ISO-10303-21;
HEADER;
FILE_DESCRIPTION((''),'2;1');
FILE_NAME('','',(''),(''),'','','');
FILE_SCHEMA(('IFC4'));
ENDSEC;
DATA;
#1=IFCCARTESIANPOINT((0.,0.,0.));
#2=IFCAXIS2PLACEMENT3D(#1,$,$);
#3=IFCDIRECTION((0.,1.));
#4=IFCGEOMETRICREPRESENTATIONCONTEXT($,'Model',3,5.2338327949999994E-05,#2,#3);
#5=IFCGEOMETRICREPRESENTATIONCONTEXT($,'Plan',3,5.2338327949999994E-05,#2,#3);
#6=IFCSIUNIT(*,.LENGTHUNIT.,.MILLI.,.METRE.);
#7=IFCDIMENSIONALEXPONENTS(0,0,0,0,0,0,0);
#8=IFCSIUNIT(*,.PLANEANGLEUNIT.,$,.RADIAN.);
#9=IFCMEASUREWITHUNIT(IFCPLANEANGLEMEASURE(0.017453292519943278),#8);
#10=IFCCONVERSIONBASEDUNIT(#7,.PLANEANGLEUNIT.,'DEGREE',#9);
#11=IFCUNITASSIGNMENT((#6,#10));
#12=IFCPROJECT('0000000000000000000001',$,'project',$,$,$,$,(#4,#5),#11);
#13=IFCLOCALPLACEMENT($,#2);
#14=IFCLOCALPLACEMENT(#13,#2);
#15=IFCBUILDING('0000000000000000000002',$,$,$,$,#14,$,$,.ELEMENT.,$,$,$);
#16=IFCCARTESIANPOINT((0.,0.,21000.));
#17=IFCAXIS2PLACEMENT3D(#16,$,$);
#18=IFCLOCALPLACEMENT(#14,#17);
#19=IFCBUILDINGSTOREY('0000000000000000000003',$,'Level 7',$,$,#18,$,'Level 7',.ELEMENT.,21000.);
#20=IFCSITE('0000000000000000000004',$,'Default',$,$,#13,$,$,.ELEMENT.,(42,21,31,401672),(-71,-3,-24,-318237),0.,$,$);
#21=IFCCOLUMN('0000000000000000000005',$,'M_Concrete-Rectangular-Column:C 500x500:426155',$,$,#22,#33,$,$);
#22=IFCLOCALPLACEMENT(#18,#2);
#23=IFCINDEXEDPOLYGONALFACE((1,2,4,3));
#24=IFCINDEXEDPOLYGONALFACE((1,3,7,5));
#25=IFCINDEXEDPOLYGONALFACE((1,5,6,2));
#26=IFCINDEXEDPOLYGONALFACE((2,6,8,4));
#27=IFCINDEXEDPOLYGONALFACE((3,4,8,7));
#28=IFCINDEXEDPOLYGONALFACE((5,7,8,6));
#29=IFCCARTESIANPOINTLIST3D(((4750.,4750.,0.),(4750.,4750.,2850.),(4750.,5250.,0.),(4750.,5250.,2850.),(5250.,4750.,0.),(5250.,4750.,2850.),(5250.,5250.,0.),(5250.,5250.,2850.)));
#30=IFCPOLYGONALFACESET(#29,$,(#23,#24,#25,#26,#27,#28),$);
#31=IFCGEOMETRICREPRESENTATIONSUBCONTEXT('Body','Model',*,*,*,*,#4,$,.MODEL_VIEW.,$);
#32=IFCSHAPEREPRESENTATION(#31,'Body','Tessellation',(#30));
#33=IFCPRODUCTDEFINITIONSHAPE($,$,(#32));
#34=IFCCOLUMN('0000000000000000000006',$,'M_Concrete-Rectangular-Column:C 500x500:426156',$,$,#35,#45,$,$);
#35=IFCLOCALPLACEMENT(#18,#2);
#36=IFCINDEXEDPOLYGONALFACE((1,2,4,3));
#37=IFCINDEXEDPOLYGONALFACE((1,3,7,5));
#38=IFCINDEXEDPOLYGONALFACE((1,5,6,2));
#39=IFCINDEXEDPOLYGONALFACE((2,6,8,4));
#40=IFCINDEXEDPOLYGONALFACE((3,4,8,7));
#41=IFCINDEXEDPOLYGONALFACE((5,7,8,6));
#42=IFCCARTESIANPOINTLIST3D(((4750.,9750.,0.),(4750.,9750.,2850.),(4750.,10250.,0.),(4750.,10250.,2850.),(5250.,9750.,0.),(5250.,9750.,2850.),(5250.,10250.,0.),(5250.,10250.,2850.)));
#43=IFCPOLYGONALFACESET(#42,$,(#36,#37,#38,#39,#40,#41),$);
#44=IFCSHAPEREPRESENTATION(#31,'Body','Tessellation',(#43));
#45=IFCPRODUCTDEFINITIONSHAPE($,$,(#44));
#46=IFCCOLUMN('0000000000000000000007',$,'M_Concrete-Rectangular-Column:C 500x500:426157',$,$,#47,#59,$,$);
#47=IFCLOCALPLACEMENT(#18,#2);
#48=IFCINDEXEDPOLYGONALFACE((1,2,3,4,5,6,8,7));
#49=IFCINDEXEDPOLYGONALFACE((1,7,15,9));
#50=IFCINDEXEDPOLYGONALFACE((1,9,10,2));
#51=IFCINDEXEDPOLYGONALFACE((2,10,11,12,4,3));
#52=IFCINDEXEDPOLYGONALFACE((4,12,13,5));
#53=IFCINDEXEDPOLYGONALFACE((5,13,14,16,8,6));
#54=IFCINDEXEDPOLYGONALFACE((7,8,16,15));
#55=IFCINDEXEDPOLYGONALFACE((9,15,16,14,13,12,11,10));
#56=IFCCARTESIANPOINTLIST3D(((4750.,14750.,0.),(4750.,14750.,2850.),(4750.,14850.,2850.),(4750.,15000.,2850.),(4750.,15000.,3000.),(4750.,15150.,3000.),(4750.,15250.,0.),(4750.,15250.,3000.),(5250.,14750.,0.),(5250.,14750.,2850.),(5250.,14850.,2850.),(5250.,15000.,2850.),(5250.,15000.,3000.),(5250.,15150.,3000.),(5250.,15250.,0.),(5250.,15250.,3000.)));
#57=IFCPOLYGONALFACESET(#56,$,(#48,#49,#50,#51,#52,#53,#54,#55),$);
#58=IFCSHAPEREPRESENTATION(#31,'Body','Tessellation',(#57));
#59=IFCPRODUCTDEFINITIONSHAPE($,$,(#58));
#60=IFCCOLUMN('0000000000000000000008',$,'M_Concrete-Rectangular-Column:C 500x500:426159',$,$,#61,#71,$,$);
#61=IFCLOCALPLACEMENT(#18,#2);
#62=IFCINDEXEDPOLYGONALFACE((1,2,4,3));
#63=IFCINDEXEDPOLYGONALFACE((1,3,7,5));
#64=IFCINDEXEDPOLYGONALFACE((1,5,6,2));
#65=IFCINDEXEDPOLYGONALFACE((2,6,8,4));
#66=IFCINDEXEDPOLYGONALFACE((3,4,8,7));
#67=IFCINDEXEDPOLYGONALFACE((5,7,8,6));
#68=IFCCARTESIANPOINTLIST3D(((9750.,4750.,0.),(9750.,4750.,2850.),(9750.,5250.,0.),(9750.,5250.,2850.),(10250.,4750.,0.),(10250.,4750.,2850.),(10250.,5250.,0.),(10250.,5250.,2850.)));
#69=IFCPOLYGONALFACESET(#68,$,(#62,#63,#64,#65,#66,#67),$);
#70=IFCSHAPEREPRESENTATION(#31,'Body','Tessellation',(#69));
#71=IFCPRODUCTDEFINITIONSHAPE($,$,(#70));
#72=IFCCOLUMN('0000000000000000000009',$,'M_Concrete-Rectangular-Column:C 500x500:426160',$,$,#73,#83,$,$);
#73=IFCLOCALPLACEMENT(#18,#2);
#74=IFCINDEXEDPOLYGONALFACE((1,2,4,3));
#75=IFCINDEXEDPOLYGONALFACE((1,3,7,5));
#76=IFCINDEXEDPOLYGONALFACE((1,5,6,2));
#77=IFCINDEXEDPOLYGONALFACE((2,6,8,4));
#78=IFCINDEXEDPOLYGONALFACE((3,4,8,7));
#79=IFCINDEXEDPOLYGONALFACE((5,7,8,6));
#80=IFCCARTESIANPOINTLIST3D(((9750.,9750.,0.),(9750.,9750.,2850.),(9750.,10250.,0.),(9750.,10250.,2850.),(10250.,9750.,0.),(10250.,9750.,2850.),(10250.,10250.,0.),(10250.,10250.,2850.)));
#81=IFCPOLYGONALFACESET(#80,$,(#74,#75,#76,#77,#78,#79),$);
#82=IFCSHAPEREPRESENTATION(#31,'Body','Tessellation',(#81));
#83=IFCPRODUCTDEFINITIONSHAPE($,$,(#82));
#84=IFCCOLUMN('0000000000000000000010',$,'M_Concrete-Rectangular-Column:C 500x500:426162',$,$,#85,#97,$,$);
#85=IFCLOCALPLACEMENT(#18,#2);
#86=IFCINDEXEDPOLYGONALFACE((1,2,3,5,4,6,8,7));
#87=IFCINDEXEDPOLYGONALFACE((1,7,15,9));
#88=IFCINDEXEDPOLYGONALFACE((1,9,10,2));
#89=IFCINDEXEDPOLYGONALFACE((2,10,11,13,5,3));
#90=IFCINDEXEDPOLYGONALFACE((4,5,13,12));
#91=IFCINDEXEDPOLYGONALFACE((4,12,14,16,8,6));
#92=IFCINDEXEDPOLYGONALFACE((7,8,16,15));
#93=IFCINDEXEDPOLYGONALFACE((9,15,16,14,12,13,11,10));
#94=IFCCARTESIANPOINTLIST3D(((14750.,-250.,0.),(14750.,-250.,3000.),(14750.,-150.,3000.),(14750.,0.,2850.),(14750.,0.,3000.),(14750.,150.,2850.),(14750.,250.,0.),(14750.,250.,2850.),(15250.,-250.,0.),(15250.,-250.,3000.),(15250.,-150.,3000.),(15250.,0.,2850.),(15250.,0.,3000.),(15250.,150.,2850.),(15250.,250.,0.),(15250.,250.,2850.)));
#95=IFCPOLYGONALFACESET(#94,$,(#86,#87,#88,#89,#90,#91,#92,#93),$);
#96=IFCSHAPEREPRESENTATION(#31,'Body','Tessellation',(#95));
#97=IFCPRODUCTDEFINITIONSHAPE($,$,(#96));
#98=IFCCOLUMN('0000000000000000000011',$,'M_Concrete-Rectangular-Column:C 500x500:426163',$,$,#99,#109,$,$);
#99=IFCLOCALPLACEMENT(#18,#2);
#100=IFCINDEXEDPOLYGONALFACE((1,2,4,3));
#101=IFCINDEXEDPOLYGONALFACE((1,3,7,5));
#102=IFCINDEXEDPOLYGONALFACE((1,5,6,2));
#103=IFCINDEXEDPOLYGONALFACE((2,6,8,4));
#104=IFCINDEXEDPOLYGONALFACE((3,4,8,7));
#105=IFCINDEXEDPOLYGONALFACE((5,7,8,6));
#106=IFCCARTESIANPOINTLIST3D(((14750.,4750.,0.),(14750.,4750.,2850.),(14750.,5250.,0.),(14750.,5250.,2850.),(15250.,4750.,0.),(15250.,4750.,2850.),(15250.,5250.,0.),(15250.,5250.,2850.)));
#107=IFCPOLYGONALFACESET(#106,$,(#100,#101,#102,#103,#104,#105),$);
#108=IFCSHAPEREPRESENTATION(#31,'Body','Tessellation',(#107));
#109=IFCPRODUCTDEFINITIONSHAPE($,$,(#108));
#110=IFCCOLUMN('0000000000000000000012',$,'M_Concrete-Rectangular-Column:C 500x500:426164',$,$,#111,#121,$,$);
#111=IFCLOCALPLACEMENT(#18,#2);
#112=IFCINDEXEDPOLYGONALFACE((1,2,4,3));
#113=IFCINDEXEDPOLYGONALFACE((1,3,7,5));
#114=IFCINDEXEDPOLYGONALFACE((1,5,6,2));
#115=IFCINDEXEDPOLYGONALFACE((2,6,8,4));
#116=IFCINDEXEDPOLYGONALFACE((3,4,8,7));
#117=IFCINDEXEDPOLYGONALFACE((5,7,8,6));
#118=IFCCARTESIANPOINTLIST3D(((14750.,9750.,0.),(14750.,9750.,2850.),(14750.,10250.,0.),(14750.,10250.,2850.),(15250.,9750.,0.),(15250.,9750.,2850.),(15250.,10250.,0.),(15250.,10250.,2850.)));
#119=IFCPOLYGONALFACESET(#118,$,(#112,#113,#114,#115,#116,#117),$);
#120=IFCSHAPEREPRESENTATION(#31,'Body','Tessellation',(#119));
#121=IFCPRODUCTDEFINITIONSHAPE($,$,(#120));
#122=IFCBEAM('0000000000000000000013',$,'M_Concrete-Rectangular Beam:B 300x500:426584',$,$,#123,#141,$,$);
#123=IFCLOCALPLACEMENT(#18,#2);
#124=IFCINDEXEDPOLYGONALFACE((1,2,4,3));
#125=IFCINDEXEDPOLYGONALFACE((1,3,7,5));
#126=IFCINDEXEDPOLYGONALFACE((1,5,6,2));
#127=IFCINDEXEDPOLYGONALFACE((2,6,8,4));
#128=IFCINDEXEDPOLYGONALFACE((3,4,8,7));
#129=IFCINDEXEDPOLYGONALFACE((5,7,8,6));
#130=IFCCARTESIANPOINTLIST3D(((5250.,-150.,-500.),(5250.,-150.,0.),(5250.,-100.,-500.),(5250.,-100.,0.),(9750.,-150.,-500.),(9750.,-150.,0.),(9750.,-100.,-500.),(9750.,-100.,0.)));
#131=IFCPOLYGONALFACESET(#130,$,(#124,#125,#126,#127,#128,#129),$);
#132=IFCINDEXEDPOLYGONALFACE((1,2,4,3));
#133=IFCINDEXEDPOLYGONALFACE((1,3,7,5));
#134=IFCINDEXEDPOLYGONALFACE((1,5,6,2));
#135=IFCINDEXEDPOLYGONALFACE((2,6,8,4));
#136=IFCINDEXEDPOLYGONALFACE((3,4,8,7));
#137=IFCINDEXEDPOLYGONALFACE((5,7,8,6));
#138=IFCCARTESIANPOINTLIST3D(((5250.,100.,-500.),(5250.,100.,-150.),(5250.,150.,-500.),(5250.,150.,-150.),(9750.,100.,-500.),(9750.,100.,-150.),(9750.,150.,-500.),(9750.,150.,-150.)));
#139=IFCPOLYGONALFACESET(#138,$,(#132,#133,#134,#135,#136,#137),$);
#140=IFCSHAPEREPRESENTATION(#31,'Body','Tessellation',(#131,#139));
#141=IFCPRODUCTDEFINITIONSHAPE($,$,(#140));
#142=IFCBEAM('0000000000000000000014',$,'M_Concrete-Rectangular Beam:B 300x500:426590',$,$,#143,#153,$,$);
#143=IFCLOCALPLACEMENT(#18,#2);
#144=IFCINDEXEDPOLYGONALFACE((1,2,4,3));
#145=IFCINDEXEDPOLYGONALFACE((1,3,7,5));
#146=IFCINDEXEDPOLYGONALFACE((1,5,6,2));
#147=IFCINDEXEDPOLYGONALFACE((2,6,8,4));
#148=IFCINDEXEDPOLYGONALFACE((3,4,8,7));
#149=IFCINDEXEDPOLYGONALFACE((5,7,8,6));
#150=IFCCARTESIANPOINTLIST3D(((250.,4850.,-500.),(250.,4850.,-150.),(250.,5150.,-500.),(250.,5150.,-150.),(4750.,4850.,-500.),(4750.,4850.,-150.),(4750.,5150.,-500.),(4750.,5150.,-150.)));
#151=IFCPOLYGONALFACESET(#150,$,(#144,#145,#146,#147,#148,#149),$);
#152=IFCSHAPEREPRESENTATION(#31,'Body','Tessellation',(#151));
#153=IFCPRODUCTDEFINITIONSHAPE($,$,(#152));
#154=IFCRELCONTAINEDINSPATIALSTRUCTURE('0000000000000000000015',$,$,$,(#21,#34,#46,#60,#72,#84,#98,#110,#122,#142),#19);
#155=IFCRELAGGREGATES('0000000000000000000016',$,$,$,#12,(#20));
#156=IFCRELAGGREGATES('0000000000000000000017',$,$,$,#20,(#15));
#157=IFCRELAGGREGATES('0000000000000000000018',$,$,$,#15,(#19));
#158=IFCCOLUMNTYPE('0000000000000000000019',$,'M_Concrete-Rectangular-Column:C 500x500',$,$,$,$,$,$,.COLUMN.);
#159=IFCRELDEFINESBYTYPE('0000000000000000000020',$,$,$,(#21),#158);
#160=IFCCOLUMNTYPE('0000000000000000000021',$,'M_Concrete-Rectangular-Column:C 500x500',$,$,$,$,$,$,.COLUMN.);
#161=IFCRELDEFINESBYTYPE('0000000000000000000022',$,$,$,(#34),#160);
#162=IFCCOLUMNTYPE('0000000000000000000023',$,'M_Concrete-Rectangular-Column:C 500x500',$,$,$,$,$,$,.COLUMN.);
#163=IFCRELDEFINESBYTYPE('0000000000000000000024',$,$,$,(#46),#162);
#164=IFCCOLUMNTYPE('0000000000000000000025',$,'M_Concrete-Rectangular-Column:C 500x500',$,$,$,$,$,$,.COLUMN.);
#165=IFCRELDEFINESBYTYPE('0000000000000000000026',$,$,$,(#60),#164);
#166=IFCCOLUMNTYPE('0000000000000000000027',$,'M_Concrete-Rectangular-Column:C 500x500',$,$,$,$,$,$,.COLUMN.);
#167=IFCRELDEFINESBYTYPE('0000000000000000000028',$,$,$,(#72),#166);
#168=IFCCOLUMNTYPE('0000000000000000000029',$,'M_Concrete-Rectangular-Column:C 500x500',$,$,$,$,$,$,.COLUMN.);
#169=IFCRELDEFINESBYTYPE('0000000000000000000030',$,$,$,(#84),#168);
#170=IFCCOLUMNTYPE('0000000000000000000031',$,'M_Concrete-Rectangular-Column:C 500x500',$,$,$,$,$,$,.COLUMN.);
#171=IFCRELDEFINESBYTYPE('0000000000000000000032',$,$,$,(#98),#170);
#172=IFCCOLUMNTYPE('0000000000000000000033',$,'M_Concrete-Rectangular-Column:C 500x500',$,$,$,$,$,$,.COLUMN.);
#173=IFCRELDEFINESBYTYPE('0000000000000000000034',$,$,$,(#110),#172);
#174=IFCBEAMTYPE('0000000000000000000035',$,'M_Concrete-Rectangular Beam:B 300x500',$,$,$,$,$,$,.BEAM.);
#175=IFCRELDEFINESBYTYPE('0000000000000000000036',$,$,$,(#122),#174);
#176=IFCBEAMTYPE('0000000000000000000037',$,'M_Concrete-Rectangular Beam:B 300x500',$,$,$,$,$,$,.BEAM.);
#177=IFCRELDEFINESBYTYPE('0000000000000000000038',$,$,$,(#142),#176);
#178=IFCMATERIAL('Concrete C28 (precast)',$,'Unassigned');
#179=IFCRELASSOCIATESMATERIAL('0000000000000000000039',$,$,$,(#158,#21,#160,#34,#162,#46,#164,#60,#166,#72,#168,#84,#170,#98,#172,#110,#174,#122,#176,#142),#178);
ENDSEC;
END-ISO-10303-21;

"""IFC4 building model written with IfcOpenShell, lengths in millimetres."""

from ifc_helpers import new_model, entity, si_unit, converted_unit, direction, frame, origin, place, context, subcontext, project, spatial, indexed_curve, outline, extrude, source, transform, mapped, material, type_object, type_shapes, element, save


model = new_model("IFC4")

# Units and contexts
model_context = context("Model", 3, precision=5.2338327949999994e-05, world=origin(), true_north=direction((0.0, 1.0)))
plan_context = context("Plan", 3, precision=5.2338327949999994e-05, world=origin(), true_north=direction((0.0, 1.0)))
body_context = subcontext(model_context, "Body", "Model", "MODEL_VIEW")
ifc_project = project(units=[si_unit("LENGTHUNIT", "METRE", prefix="MILLI"), converted_unit("PLANEANGLEUNIT", "DEGREE", entity("IfcPlaneAngleMeasure", 0.017453292519943278), si_unit("PLANEANGLEUNIT", "RADIAN"), dimensions=[0, 0, 0, 0, 0, 0, 0])], contexts=[model_context, plan_context])

# Site, building, storey
site_placement = place(None, origin())
site = spatial("IfcSite", under=ifc_project, at=site_placement, Name="Default", CompositionType="ELEMENT", RefLatitude=(42, 21, 31, 401672), RefLongitude=(-71, -3, -24, -318237), RefElevation=0.0)
building_placement = place(site_placement, origin())
building = spatial("IfcBuilding", under=site, at=building_placement, CompositionType="ELEMENT")
storey_placement = place(building_placement, frame((0.0, 0.0, 21000.0)))
storey = spatial("IfcBuildingStorey", under=building, at=storey_placement, Name="Level 7", LongName="Level 7", CompositionType="ELEMENT", Elevation=21000.0)

# Columns
ifc_material = material(Name="Concrete C28 (precast)", Category="Unassigned")
column_type_1 = type_object("IfcColumnType", Name="M_Concrete-Rectangular-Column:C 500x500", PredefinedType="COLUMN", material=ifc_material)
shared_shape_1 = source(origin(), body_context, "Body", "SweptSolid", [
    extrude(outline(indexed_curve([(-250.0, -250.0), (250.0, -250.0), (250.0, 250.0), (-250.0, 250.0), (-250.0, -250.0)], self_intersect=False)), frame((5000.0, 5000.0, 21000.0), z_axis=(0.0, 0.0, 1.0), x_axis=(-1.0, 0.0, 0.0)), (0.0, 0.0, 1.0), 2850.0),
])
type_shapes(column_type_1, [shared_shape_1])
column_1_placement = place(storey_placement, frame((0.0, 0.0, -21000.0)))
element("IfcColumn", 1, at=column_1_placement, inside=storey, type_object=column_type_1, material=ifc_material, Name="M_Concrete-Rectangular-Column:C 500x500:426155", context=body_context, shape_type="MappedRepresentation", body=[
    mapped(shared_shape_1, transform((0.0, 0.0, 0.0), scale=1.0)),
])
column_type_2 = type_object("IfcColumnType", Name="M_Concrete-Rectangular-Column:C 500x500", PredefinedType="COLUMN", material=ifc_material)
shared_shape_2 = source(origin(), body_context, "Body", "SweptSolid", [
    extrude(outline(indexed_curve([(-250.0, -250.0), (250.0, -250.0), (250.0, 250.0), (-250.0, 250.0), (-250.0, -250.0)], self_intersect=False)), frame((5000.0, 10000.0, 21000.0), z_axis=(0.0, 0.0, 1.0), x_axis=(-1.0, 0.0, 0.0)), (0.0, 0.0, 1.0), 2850.0),
])
type_shapes(column_type_2, [shared_shape_2])
column_2_placement = place(storey_placement, frame((0.0, 0.0, -21000.0)))
element("IfcColumn", 2, at=column_2_placement, inside=storey, type_object=column_type_2, material=ifc_material, Name="M_Concrete-Rectangular-Column:C 500x500:426156", context=body_context, shape_type="MappedRepresentation", body=[
    mapped(shared_shape_2, transform((0.0, 0.0, 0.0), scale=1.0)),
])
column_type_3 = type_object("IfcColumnType", Name="M_Concrete-Rectangular-Column:C 500x500", PredefinedType="COLUMN", material=ifc_material)
shared_shape_3 = source(origin(), body_context, "Body", "SweptSolid", [
    extrude(outline(indexed_curve([(-2193.7, -250.0), (806.2, -250.0), (806.2, -150.0), (806.2, 0.0), (656.2, 0.0), (656.2, 150.0), (656.2, 250.0), (-2193.7, 250.0), (-2193.7, -250.0)], self_intersect=False)), frame((4750.0, 15000.0, 23193.8), z_axis=(1.0, 0.0, 0.0), x_axis=(0.0, 0.0, 1.0)), (0.0, 0.0, 1.0), 500.0),
])
type_shapes(column_type_3, [shared_shape_3])
column_3_placement = place(storey_placement, frame((0.0, 0.0, -21000.0)))
element("IfcColumn", 3, at=column_3_placement, inside=storey, type_object=column_type_3, material=ifc_material, Name="M_Concrete-Rectangular-Column:C 500x500:426157", context=body_context, shape_type="MappedRepresentation", body=[
    mapped(shared_shape_3, transform((0.0, 0.0, 0.0), scale=1.0)),
])
column_type_4 = type_object("IfcColumnType", Name="M_Concrete-Rectangular-Column:C 500x500", PredefinedType="COLUMN", material=ifc_material)
shared_shape_4 = source(origin(), body_context, "Body", "SweptSolid", [
    extrude(outline(indexed_curve([(-250.0, -250.0), (250.0, -250.0), (250.0, 250.0), (-250.0, 250.0), (-250.0, -250.0)], self_intersect=False)), frame((10000.0, 5000.0, 21000.0), z_axis=(0.0, 0.0, 1.0), x_axis=(-1.0, 0.0, 0.0)), (0.0, 0.0, 1.0), 2850.0),
])
type_shapes(column_type_4, [shared_shape_4])
column_4_placement = place(storey_placement, frame((0.0, 0.0, -21000.0)))
element("IfcColumn", 4, at=column_4_placement, inside=storey, type_object=column_type_4, material=ifc_material, Name="M_Concrete-Rectangular-Column:C 500x500:426159", context=body_context, shape_type="MappedRepresentation", body=[
    mapped(shared_shape_4, transform((0.0, 0.0, 0.0), scale=1.0)),
])
column_type_5 = type_object("IfcColumnType", Name="M_Concrete-Rectangular-Column:C 500x500", PredefinedType="COLUMN", material=ifc_material)
shared_shape_5 = source(origin(), body_context, "Body", "SweptSolid", [
    extrude(outline(indexed_curve([(-250.0, -250.0), (250.0, -250.0), (250.0, 250.0), (-250.0, 250.0), (-250.0, -250.0)], self_intersect=False)), frame((10000.0, 10000.0, 21000.0), z_axis=(0.0, 0.0, 1.0), x_axis=(-1.0, 0.0, 0.0)), (0.0, 0.0, 1.0), 2850.0),
])
type_shapes(column_type_5, [shared_shape_5])
column_5_placement = place(storey_placement, frame((0.0, 0.0, -21000.0)))
element("IfcColumn", 5, at=column_5_placement, inside=storey, type_object=column_type_5, material=ifc_material, Name="M_Concrete-Rectangular-Column:C 500x500:426160", context=body_context, shape_type="MappedRepresentation", body=[
    mapped(shared_shape_5, transform((0.0, 0.0, 0.0), scale=1.0)),
])
column_type_6 = type_object("IfcColumnType", Name="M_Concrete-Rectangular-Column:C 500x500", PredefinedType="COLUMN", material=ifc_material)
shared_shape_6 = source(origin(), body_context, "Body", "SweptSolid", [
    extrude(outline(indexed_curve([(-2193.7, -250.0), (656.2, -250.0), (656.2, -150.0), (656.2, 0.0), (806.2, 0.0), (806.2, 150.0), (806.2, 250.0), (-2193.7, 250.0), (-2193.7, -250.0)], self_intersect=False)), frame((14750.0, 0.0, 23193.8), z_axis=(1.0, 0.0, 0.0), x_axis=(0.0, 0.0, 1.0)), (0.0, 0.0, 1.0), 500.0),
])
type_shapes(column_type_6, [shared_shape_6])
column_6_placement = place(storey_placement, frame((0.0, 0.0, -21000.0)))
element("IfcColumn", 6, at=column_6_placement, inside=storey, type_object=column_type_6, material=ifc_material, Name="M_Concrete-Rectangular-Column:C 500x500:426162", context=body_context, shape_type="MappedRepresentation", body=[
    mapped(shared_shape_6, transform((0.0, 0.0, 0.0), scale=1.0)),
])
column_type_7 = type_object("IfcColumnType", Name="M_Concrete-Rectangular-Column:C 500x500", PredefinedType="COLUMN", material=ifc_material)
shared_shape_7 = source(origin(), body_context, "Body", "SweptSolid", [
    extrude(outline(indexed_curve([(-250.0, -250.0), (250.0, -250.0), (250.0, 250.0), (-250.0, 250.0), (-250.0, -250.0)], self_intersect=False)), frame((15000.0, 5000.0, 21000.0), z_axis=(0.0, 0.0, 1.0), x_axis=(-1.0, 0.0, 0.0)), (0.0, 0.0, 1.0), 2850.0),
])
type_shapes(column_type_7, [shared_shape_7])
column_7_placement = place(storey_placement, frame((0.0, 0.0, -21000.0)))
element("IfcColumn", 7, at=column_7_placement, inside=storey, type_object=column_type_7, material=ifc_material, Name="M_Concrete-Rectangular-Column:C 500x500:426163", context=body_context, shape_type="MappedRepresentation", body=[
    mapped(shared_shape_7, transform((0.0, 0.0, 0.0), scale=1.0)),
])
column_type_8 = type_object("IfcColumnType", Name="M_Concrete-Rectangular-Column:C 500x500", PredefinedType="COLUMN", material=ifc_material)
shared_shape_8 = source(origin(), body_context, "Body", "SweptSolid", [
    extrude(outline(indexed_curve([(-250.0, -250.0), (250.0, -250.0), (250.0, 250.0), (-250.0, 250.0), (-250.0, -250.0)], self_intersect=False)), frame((15000.0, 10000.0, 21000.0), z_axis=(0.0, 0.0, 1.0), x_axis=(-1.0, 0.0, 0.0)), (0.0, 0.0, 1.0), 2850.0),
])
type_shapes(column_type_8, [shared_shape_8])
column_8_placement = place(storey_placement, frame((0.0, 0.0, -21000.0)))
element("IfcColumn", 8, at=column_8_placement, inside=storey, type_object=column_type_8, material=ifc_material, Name="M_Concrete-Rectangular-Column:C 500x500:426164", context=body_context, shape_type="MappedRepresentation", body=[
    mapped(shared_shape_8, transform((0.0, 0.0, 0.0), scale=1.0)),
])

# Beams
beam_type_1 = type_object("IfcBeamType", Name="M_Concrete-Rectangular Beam:B 300x500", PredefinedType="BEAM", material=ifc_material)
shared_shape_9 = source(origin(), body_context, "Body", "SweptSolid", [
    extrude(outline(indexed_curve([(-250.0, -25.0), (250.0, -25.0), (250.0, 25.0), (-250.0, 25.0), (-250.0, -25.0)], self_intersect=False)), frame((5250.0, -125.0, 20750.0), z_axis=(1.0, 0.0, 0.0), x_axis=(0.0, 0.0, -1.0)), (0.0, 0.0, 1.0), 4500.0),
    extrude(outline(indexed_curve([(-175.0, -25.0), (175.0, -25.0), (175.0, 25.0), (-175.0, 25.0), (-175.0, -25.0)], self_intersect=False)), frame((5250.0, 125.0, 20675.0), z_axis=(1.0, 0.0, 0.0), x_axis=(0.0, 0.0, -1.0)), (0.0, 0.0, 1.0), 4500.0),
])
type_shapes(beam_type_1, [shared_shape_9])
beam_1_placement = place(storey_placement, frame((0.0, 0.0, -21000.0)))
element("IfcBeam", 9, at=beam_1_placement, inside=storey, type_object=beam_type_1, material=ifc_material, Name="M_Concrete-Rectangular Beam:B 300x500:426584", context=body_context, shape_type="MappedRepresentation", body=[
    mapped(shared_shape_9, transform((0.0, 0.0, 0.0), scale=1.0)),
])
beam_type_2 = type_object("IfcBeamType", Name="M_Concrete-Rectangular Beam:B 300x500", PredefinedType="BEAM", material=ifc_material)
shared_shape_10 = source(origin(), body_context, "Body", "SweptSolid", [
    extrude(outline(indexed_curve([(-175.0, -150.0), (175.0, -150.0), (175.0, 150.0), (-175.0, 150.0), (-175.0, -150.0)], self_intersect=False)), frame((250.0, 5000.0, 20675.0), z_axis=(1.0, 0.0, 0.0), x_axis=(0.0, 0.0, -1.0)), (0.0, 0.0, 1.0), 4500.0),
])
type_shapes(beam_type_2, [shared_shape_10])
beam_2_placement = place(storey_placement, frame((0.0, 0.0, -21000.0)))
element("IfcBeam", 10, at=beam_2_placement, inside=storey, type_object=beam_type_2, material=ifc_material, Name="M_Concrete-Rectangular Beam:B 300x500:426590", context=body_context, shape_type="MappedRepresentation", body=[
    mapped(shared_shape_10, transform((0.0, 0.0, 0.0), scale=1.0)),
])

save(model, "model.ifc")
